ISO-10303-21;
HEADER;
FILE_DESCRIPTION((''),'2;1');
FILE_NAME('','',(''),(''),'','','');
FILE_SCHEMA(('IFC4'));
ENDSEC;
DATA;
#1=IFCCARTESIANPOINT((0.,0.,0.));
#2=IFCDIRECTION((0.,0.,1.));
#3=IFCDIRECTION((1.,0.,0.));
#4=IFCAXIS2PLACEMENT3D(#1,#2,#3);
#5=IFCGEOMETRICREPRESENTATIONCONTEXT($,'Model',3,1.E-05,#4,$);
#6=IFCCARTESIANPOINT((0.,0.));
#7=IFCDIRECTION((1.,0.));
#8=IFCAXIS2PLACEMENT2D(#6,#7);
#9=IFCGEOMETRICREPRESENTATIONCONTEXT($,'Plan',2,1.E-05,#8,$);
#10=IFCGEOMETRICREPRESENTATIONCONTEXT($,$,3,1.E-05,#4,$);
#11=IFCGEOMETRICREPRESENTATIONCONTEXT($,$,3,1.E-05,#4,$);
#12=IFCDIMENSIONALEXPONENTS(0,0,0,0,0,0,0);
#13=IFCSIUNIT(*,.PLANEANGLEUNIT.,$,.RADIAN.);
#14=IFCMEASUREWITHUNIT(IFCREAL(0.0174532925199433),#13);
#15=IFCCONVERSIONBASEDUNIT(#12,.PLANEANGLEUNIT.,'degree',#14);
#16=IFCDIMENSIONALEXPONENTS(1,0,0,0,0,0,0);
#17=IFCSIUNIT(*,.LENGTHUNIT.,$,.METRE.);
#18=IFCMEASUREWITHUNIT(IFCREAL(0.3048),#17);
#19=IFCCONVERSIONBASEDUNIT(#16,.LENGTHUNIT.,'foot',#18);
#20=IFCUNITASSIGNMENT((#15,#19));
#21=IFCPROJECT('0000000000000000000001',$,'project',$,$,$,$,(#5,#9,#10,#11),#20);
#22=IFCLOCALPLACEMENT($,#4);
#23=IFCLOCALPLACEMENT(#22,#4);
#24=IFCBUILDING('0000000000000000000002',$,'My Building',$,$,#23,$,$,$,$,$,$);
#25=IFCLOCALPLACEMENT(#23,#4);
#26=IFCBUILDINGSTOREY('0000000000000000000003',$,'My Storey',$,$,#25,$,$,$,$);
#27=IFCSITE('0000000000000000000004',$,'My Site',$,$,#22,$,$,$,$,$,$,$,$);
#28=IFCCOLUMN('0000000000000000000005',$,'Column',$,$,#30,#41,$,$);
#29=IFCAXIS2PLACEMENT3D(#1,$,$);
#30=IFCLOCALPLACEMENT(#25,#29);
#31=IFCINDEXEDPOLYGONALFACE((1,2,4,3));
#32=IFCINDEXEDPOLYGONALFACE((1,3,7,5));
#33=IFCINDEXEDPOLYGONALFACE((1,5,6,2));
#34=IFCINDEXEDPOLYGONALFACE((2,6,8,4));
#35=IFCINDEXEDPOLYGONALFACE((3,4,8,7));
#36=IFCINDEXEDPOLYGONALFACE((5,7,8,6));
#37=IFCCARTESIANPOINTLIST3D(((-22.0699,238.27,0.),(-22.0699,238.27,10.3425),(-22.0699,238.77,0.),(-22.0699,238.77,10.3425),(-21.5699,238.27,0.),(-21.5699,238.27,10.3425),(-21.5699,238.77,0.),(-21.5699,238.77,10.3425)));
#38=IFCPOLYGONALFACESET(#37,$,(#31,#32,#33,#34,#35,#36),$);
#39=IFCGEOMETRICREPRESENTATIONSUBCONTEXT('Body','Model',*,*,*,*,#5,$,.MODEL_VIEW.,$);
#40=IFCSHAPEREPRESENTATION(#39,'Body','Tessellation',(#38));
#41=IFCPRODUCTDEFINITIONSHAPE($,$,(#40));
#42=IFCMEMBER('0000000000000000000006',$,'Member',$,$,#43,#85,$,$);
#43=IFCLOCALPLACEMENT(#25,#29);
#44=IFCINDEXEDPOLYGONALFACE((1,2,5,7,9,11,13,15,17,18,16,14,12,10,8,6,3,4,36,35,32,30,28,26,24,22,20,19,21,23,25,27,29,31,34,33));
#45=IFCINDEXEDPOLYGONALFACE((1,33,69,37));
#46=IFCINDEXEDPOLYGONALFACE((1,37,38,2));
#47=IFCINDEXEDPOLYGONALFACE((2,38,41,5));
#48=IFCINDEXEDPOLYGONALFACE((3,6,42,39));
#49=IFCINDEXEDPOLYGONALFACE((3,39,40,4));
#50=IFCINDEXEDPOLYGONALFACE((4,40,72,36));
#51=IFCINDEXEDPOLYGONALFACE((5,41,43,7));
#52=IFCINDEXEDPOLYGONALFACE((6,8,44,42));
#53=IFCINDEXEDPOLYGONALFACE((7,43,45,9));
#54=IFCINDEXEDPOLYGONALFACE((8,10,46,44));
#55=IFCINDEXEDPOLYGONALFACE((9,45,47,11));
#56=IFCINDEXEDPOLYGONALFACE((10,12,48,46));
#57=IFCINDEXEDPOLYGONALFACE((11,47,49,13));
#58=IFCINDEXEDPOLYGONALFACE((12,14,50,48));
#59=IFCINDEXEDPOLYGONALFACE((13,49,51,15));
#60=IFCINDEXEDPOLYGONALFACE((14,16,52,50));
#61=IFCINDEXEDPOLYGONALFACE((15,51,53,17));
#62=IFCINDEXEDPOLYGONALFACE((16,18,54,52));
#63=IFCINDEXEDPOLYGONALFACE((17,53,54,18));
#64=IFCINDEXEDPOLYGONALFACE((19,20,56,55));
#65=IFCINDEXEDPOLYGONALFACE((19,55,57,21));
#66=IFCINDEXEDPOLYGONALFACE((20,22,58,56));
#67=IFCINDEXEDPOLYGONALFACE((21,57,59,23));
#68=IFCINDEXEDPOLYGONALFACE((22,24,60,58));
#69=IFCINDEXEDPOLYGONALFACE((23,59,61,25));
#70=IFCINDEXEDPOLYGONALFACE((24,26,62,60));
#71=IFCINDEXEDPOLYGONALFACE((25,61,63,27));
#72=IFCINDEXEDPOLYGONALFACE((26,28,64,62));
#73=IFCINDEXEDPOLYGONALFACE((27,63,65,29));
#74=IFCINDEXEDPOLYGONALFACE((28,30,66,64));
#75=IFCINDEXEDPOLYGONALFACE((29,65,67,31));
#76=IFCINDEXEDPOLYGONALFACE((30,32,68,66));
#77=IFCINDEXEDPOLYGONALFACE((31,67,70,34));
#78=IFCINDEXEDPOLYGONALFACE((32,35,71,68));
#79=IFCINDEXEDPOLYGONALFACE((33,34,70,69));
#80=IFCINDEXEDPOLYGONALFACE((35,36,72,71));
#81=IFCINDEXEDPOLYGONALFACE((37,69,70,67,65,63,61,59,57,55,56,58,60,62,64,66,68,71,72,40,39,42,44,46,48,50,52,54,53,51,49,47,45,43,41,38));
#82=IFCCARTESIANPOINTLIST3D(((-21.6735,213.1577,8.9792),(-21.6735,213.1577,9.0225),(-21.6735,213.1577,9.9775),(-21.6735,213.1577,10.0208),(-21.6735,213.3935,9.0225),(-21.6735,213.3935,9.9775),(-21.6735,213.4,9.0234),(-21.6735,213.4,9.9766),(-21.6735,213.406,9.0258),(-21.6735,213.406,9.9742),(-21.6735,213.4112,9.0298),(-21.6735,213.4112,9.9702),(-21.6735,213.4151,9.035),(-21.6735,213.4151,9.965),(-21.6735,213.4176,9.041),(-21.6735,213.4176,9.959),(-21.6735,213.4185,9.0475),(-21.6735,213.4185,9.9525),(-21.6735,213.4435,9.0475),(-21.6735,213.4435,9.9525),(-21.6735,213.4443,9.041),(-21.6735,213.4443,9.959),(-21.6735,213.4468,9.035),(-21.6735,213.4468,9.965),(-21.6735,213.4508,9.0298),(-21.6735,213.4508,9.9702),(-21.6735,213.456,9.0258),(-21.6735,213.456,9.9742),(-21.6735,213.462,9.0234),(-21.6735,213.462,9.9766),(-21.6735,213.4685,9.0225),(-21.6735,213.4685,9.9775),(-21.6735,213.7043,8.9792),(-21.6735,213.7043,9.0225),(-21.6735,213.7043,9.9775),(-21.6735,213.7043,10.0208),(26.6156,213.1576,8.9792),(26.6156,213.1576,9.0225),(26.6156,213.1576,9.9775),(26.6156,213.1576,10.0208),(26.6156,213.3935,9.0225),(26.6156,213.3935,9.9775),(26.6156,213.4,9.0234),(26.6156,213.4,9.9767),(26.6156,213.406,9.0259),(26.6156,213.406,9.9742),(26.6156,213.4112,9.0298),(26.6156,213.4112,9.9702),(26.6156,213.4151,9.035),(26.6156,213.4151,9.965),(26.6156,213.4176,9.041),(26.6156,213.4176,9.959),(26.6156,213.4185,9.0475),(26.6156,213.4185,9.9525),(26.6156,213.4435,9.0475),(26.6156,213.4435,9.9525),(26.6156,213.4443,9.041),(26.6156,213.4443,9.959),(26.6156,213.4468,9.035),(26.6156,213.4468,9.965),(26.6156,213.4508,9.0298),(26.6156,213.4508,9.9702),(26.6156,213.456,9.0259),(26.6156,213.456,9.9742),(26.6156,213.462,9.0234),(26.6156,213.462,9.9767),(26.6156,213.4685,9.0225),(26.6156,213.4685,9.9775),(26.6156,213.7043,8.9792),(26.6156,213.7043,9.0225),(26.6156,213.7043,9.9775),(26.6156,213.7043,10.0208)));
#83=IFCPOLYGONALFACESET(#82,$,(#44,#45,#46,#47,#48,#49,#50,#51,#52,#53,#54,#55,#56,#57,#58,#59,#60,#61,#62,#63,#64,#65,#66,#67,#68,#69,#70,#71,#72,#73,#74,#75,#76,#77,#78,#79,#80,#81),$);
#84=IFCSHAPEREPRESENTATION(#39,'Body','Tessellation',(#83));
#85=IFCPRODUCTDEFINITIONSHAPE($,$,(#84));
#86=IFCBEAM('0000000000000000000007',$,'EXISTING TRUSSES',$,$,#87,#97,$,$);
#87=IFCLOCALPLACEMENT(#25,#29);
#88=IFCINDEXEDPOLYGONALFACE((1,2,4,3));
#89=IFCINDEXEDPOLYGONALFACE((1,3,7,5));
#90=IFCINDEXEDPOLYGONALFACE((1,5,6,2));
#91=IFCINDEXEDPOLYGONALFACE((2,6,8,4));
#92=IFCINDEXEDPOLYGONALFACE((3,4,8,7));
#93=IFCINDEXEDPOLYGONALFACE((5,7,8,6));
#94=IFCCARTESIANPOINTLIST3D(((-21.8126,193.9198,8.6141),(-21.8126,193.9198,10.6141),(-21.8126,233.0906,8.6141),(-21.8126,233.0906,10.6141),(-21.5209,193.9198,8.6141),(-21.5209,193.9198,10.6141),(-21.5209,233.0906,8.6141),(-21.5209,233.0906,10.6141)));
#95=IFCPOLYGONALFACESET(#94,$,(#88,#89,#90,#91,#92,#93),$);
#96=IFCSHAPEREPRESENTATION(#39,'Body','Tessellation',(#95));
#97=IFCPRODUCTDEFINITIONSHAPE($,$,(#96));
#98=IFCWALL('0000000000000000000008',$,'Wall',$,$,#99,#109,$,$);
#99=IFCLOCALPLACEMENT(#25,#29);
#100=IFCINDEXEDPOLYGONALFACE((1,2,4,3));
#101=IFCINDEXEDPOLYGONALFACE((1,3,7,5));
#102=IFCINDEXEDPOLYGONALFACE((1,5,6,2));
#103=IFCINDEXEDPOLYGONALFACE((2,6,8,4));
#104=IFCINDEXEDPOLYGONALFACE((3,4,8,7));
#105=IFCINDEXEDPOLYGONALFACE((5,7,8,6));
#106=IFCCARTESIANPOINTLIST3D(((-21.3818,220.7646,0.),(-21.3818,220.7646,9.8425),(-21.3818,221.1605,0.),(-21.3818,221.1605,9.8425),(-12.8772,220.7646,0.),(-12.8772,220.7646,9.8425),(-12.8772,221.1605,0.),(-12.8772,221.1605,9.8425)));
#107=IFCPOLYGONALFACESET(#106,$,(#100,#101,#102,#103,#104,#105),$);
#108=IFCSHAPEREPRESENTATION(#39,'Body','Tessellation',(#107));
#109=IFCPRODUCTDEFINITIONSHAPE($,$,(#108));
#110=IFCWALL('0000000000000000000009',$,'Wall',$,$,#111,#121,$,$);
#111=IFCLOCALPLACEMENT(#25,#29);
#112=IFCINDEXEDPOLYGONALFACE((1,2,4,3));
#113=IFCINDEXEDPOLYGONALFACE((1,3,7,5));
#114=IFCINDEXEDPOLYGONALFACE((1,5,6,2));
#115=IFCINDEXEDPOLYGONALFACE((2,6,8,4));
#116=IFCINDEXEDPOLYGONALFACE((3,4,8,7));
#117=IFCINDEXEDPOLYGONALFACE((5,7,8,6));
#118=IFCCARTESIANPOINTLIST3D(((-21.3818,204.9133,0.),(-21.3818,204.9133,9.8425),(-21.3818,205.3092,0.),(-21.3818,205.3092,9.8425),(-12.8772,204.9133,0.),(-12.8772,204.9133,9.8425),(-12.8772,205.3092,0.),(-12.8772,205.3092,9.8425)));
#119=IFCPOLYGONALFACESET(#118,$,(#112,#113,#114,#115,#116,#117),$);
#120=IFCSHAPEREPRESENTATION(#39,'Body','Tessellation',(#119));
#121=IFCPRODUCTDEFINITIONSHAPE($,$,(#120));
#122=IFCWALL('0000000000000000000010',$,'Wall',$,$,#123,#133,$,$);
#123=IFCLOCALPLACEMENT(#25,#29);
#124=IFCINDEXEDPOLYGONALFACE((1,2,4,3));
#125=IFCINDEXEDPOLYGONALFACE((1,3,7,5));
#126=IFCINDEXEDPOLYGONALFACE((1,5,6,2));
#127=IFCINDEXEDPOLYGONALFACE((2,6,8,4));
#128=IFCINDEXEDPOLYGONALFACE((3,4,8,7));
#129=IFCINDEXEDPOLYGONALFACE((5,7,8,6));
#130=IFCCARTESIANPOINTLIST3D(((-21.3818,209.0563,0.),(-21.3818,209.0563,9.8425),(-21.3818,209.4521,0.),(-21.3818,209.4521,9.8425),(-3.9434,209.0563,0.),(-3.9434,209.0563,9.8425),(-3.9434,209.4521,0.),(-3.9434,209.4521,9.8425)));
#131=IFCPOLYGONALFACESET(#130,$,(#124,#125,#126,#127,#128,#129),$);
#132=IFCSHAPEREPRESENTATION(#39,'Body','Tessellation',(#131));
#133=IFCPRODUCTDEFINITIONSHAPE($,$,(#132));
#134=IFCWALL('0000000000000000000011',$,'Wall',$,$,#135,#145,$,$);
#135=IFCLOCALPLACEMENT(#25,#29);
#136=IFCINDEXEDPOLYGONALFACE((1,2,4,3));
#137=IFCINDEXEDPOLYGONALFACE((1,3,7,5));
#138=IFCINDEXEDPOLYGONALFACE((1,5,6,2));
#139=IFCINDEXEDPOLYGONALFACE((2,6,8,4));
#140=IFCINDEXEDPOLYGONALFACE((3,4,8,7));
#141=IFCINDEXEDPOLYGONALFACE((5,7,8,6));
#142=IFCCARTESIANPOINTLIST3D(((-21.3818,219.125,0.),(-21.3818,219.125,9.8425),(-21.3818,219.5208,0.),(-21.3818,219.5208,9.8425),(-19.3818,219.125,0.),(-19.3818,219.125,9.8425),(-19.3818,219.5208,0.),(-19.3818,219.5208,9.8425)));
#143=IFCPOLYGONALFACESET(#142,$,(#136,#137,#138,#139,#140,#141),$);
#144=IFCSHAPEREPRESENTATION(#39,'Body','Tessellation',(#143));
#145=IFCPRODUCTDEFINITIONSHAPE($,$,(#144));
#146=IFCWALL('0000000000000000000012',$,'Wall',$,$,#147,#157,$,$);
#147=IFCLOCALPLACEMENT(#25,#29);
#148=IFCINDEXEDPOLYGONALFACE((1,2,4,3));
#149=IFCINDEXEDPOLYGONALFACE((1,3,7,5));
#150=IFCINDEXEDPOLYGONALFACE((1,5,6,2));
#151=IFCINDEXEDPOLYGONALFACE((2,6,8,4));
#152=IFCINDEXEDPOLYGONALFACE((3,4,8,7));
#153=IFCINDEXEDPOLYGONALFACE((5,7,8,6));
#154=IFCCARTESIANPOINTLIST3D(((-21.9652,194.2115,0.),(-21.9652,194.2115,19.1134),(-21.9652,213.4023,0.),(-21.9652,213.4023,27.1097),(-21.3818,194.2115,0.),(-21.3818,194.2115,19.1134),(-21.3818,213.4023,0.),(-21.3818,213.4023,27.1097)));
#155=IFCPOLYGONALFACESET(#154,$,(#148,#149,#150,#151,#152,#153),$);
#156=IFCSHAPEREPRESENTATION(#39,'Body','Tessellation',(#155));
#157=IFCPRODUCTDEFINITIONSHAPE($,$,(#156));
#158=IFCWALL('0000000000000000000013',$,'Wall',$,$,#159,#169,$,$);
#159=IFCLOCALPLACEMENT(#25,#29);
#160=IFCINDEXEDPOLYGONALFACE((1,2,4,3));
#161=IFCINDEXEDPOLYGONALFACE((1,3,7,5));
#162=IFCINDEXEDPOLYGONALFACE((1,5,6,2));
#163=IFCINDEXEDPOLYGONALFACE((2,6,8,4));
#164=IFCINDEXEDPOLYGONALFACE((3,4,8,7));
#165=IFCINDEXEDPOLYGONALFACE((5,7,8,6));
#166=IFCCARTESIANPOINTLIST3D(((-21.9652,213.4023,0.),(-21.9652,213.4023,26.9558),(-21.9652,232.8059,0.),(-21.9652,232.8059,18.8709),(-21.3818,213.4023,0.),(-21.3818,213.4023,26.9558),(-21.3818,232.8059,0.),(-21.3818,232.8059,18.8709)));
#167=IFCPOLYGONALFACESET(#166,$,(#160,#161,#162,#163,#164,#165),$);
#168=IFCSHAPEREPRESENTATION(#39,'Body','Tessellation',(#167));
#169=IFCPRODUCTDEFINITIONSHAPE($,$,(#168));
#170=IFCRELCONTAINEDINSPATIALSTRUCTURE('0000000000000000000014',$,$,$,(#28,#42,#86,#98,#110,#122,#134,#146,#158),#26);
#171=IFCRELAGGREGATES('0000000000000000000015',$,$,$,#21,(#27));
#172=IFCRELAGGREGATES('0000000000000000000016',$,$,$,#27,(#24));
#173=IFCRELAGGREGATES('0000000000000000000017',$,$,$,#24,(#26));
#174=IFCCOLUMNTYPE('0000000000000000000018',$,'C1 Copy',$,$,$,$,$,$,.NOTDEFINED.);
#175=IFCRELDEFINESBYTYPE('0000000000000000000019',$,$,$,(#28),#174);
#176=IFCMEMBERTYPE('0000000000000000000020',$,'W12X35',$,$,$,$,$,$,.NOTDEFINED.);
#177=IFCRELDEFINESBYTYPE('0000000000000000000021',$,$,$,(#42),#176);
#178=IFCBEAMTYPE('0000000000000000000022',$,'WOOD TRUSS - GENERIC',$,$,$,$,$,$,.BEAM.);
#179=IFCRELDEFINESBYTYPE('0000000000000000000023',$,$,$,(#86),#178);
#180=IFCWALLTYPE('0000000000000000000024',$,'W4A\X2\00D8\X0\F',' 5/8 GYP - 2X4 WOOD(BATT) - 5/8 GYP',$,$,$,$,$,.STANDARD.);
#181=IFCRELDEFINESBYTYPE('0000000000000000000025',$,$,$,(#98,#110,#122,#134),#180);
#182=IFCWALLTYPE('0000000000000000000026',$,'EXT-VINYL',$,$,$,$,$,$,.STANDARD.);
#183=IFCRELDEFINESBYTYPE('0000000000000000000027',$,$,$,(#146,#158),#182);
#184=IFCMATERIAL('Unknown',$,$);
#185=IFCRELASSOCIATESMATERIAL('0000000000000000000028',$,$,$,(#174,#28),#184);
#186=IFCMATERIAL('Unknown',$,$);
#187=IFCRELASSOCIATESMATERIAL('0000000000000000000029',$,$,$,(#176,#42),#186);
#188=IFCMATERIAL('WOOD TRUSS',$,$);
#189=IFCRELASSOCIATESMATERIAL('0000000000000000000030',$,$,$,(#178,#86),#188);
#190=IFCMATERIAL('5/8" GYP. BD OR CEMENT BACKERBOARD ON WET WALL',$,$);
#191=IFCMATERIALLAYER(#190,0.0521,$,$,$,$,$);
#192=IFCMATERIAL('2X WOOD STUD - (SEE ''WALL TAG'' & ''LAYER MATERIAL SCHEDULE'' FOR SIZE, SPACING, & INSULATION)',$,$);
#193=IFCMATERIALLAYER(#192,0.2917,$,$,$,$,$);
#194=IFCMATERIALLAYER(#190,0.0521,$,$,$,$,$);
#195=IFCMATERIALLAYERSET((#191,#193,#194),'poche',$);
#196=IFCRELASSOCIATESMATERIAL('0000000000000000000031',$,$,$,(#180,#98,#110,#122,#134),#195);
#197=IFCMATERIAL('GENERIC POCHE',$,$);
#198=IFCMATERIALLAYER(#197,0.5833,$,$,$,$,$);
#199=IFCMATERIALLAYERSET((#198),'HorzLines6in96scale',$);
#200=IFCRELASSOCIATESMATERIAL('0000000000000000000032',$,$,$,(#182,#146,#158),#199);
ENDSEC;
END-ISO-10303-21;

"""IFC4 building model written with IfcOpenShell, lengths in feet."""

from ifc_helpers import new_model, entity, si_unit, converted_unit, frame, origin_with_axes, origin_2d_with_axis, place, context, subcontext, project, spatial, indexed_curve, rectangle, i_section, outline, extrude, clip, halfspace, material, layer, layer_set, layer_usage, material_profile, profile_set, profile_usage, type_object, element, save


model = new_model("IFC4")

# Units and contexts
model_context = context("Model", 3, precision=1e-05, world=origin_with_axes())
plan_context = context("Plan", 2, precision=1e-05, world=origin_2d_with_axis())
context_of_model_1 = context(None, 3, precision=1e-05, world=origin_with_axes())
context_of_model_2 = context(None, 3, precision=1e-05, world=origin_with_axes())
body_context = subcontext(model_context, "Body", "Model", "MODEL_VIEW")
ifc_project = project(units=[converted_unit("PLANEANGLEUNIT", "degree", entity("IfcReal", 0.0174532925199433), si_unit("PLANEANGLEUNIT", "RADIAN"), dimensions=[0, 0, 0, 0, 0, 0, 0]), converted_unit("LENGTHUNIT", "foot", entity("IfcReal", 0.3048), si_unit("LENGTHUNIT", "METRE"), dimensions=[1, 0, 0, 0, 0, 0, 0])], contexts=[model_context, plan_context, context_of_model_1, context_of_model_2])

# Site, building, storey
site_placement = place(None, origin_with_axes())
site = spatial("IfcSite", under=ifc_project, at=site_placement, Name="My Site")
building_placement = place(site_placement, origin_with_axes())
building = spatial("IfcBuilding", under=site, at=building_placement, Name="My Building")
storey_placement = place(building_placement, origin_with_axes())
storey = spatial("IfcBuildingStorey", under=building, at=storey_placement, Name="My Storey")

# Column
ifc_material_1 = material(Name="Unknown")
ifc_material_profile_1 = material_profile(ifc_material_1, rectangle(XDim=0.5, YDim=0.5))
ifc_profile_set_1 = profile_set([ifc_material_profile_1])
ifc_profile_usage_1 = profile_usage(ifc_profile_set_1, cardinal=5)
column_type = type_object("IfcColumnType", Name="C1 Copy", PredefinedType="NOTDEFINED", material=ifc_profile_set_1)
column_placement = place(storey_placement, frame((-21.8199, 238.52, 0.0), z_axis=(0.0, 0.0, 1.0), x_axis=(1.0, 0.0, 0.0)))
element("IfcColumn", 1, at=column_placement, inside=storey, type_object=column_type, material=ifc_profile_usage_1, Name="Column", context=body_context, shape_type="SweptSolid", body=[
    extrude(rectangle(XDim=0.5, YDim=0.5), origin_with_axes(), (0.0, 0.0, 1.0), 10.3425),
])

# Member
ifc_material_2 = material(Name="Unknown")
ifc_material_profile_2 = material_profile(ifc_material_2, i_section(OverallWidth=0.5467, OverallDepth=1.0417, WebThickness=0.025, FlangeThickness=0.0433, FilletRadius=0.025))
ifc_profile_set_2 = profile_set([ifc_material_profile_2])
ifc_profile_usage_2 = profile_usage(ifc_profile_set_2, cardinal=5)
member_type = type_object("IfcMemberType", Name="W12X35", PredefinedType="NOTDEFINED", material=ifc_profile_set_2)
member_placement = place(storey_placement, frame((-21.6735, 213.431, 9.5), z_axis=(1.0, 0.0, 0.0), x_axis=(0.0, 1.0, 0.0)))
element("IfcMember", 2, at=member_placement, inside=storey, type_object=member_type, material=ifc_profile_usage_2, Name="Member", context=body_context, shape_type="SweptSolid", body=[
    extrude(i_section(OverallWidth=0.5467, OverallDepth=1.0417, WebThickness=0.025, FlangeThickness=0.0433, FilletRadius=0.025), origin_with_axes(), (0.0, 0.0, 1.0), 48.2891),
])

# Beam
ifc_material_3 = material(Name="WOOD TRUSS")
ifc_material_profile_3 = material_profile(ifc_material_3, rectangle(XDim=0.2917, YDim=2.0))
ifc_profile_set_3 = profile_set([ifc_material_profile_3])
ifc_profile_usage_3 = profile_usage(ifc_profile_set_3, cardinal=5)
beam_type = type_object("IfcBeamType", Name="WOOD TRUSS - GENERIC", PredefinedType="BEAM", material=ifc_profile_set_3)
beam_placement = place(storey_placement, frame((-21.6667, 193.9198, 9.6141), z_axis=(0.0, 1.0, 0.0), x_axis=(-1.0, 0.0, 0.0)))
element("IfcBeam", 3, at=beam_placement, inside=storey, type_object=beam_type, material=ifc_profile_usage_3, Name="EXISTING TRUSSES", context=body_context, shape_type="SweptSolid", body=[
    extrude(rectangle(XDim=0.2917, YDim=2.0), origin_with_axes(), (0.0, 0.0, 1.0), 39.1707),
])

# Walls
ifc_material_4 = material(Name="5/8\" GYP. BD OR CEMENT BACKERBOARD ON WET WALL")
ifc_layer_1 = layer(ifc_material_4, 0.0521)
ifc_material_5 = material(Name="2X WOOD STUD - (SEE 'WALL TAG' & 'LAYER MATERIAL SCHEDULE' FOR SIZE, SPACING, & INSULATION)")
ifc_layer_2 = layer(ifc_material_5, 0.2917)
ifc_layer_3 = layer(ifc_material_4, 0.0521)
ifc_layer_set_1 = layer_set([ifc_layer_1, ifc_layer_2, ifc_layer_3], Name="poche")
ifc_layer_usage_1 = layer_usage(ifc_layer_set_1, "AXIS2", "POSITIVE", 0.0)
wall_type_1 = type_object("IfcWallType", Name="W4AØF", Description=" 5/8 GYP - 2X4 WOOD(BATT) - 5/8 GYP", PredefinedType="STANDARD", material=ifc_layer_set_1)
wall_1_placement = place(storey_placement, frame((-21.3818, 220.7646, 0.0), z_axis=(0.0, 0.0, 1.0), x_axis=(1.0, 0.0, 0.0)))
element("IfcWall", 4, at=wall_1_placement, inside=storey, type_object=wall_type_1, material=ifc_layer_usage_1, Name="Wall", context=body_context, shape_type="SweptSolid", body=[
    extrude(outline(indexed_curve([(0.0, 0.0), (0.0, 0.3958), (8.5047, 0.3958), (8.5047, 0.0), (0.0, 0.0)], self_intersect=False)), origin_with_axes(), (0.0, 0.0, 1.0), 9.8425),
])
ifc_layer_usage_2 = layer_usage(ifc_layer_set_1, "AXIS2", "POSITIVE", 0.0)
wall_2_placement = place(storey_placement, frame((-21.3818, 204.9133, 0.0), z_axis=(0.0, 0.0, 1.0), x_axis=(1.0, 0.0, 0.0)))
element("IfcWall", 5, at=wall_2_placement, inside=storey, type_object=wall_type_1, material=ifc_layer_usage_2, Name="Wall", context=body_context, shape_type="SweptSolid", body=[
    extrude(outline(indexed_curve([(0.0, 0.0), (0.0, 0.3958), (8.5046, 0.3958), (8.5046, 0.0), (0.0, 0.0)], self_intersect=False)), origin_with_axes(), (0.0, 0.0, 1.0), 9.8425),
])
ifc_layer_usage_3 = layer_usage(ifc_layer_set_1, "AXIS2", "POSITIVE", 0.0)
wall_3_placement = place(storey_placement, frame((-21.3818, 209.0563, 0.0), z_axis=(0.0, 0.0, 1.0), x_axis=(1.0, -0.000001, 0.0)))
element("IfcWall", 6, at=wall_3_placement, inside=storey, type_object=wall_type_1, material=ifc_layer_usage_3, Name="Wall", context=body_context, shape_type="SweptSolid", body=[
    extrude(outline(indexed_curve([(0.0, 0.0), (0.0, 0.3958), (17.4385, 0.3958), (17.4385, 0.0), (0.0, 0.0)], self_intersect=False)), origin_with_axes(), (0.0, 0.0, 1.0), 9.8425),
])
ifc_layer_usage_4 = layer_usage(ifc_layer_set_1, "AXIS2", "POSITIVE", 0.0)
wall_4_placement = place(storey_placement, frame((-21.3818, 219.125, 0.0), z_axis=(0.0, 0.0, 1.0), x_axis=(1.0, -0.000001, 0.0)))
element("IfcWall", 7, at=wall_4_placement, inside=storey, type_object=wall_type_1, material=ifc_layer_usage_4, Name="Wall", context=body_context, shape_type="SweptSolid", body=[
    extrude(outline(indexed_curve([(0.0, 0.0), (0.0, 0.3958), (2.0, 0.3958), (2.0, 0.0), (0.0, 0.0)], self_intersect=False)), origin_with_axes(), (0.0, 0.0, 1.0), 9.8425),
])
ifc_material_6 = material(Name="GENERIC POCHE")
ifc_layer_4 = layer(ifc_material_6, 0.5833)
ifc_layer_set_2 = layer_set([ifc_layer_4], Name="HorzLines6in96scale")
ifc_layer_usage_5 = layer_usage(ifc_layer_set_2, "AXIS2", "POSITIVE", 0.0)
wall_type_2 = type_object("IfcWallType", Name="EXT-VINYL", PredefinedType="STANDARD", material=ifc_layer_set_2)
wall_5_placement = place(storey_placement, frame((-21.3818, 194.2115, 0.0), z_axis=(0.0, 0.0, 1.0), x_axis=(0.0, 1.0, 0.0)))
element("IfcWall", 8, at=wall_5_placement, inside=storey, type_object=wall_type_2, material=ifc_layer_usage_5, Name="Wall", context=body_context, shape_type="Clipping", body=[
    clip(extrude(outline(indexed_curve([(0.0, 0.0), (0.0, 0.5833), (19.1908, 0.5833), (19.1908, 0.0), (0.0, 0.0)], self_intersect=False)), origin_with_axes(), (0.0, 0.0, 1.0), 27.1097), halfspace(frame((19.1908, 0.0, 27.1097), z_axis=(-0.384618, 0.0, 0.923076), x_axis=(0.0, -1.0, 0.0)), False)),
])
ifc_layer_usage_6 = layer_usage(ifc_layer_set_2, "AXIS2", "POSITIVE", 0.0)
wall_6_placement = place(storey_placement, frame((-21.3818, 213.4023, 0.0), z_axis=(0.0, 0.0, 1.0), x_axis=(0.0, 1.0, 0.0)))
element("IfcWall", 9, at=wall_6_placement, inside=storey, type_object=wall_type_2, material=ifc_layer_usage_6, Name="Wall", context=body_context, shape_type="Clipping", body=[
    clip(extrude(outline(indexed_curve([(0.0, 0.0), (0.0, 0.5833), (19.4036, 0.5833), (19.4036, 0.0), (0.0, 0.0)], self_intersect=False)), origin_with_axes(), (0.0, 0.0, 1.0), 26.9558), halfspace(frame((0.0, 0.0, 26.9558), z_axis=(0.384618, 0.0, 0.923076), x_axis=(-0.000001, 1.0, 0.0)), False)),
])

save(model, "model.ifc")
